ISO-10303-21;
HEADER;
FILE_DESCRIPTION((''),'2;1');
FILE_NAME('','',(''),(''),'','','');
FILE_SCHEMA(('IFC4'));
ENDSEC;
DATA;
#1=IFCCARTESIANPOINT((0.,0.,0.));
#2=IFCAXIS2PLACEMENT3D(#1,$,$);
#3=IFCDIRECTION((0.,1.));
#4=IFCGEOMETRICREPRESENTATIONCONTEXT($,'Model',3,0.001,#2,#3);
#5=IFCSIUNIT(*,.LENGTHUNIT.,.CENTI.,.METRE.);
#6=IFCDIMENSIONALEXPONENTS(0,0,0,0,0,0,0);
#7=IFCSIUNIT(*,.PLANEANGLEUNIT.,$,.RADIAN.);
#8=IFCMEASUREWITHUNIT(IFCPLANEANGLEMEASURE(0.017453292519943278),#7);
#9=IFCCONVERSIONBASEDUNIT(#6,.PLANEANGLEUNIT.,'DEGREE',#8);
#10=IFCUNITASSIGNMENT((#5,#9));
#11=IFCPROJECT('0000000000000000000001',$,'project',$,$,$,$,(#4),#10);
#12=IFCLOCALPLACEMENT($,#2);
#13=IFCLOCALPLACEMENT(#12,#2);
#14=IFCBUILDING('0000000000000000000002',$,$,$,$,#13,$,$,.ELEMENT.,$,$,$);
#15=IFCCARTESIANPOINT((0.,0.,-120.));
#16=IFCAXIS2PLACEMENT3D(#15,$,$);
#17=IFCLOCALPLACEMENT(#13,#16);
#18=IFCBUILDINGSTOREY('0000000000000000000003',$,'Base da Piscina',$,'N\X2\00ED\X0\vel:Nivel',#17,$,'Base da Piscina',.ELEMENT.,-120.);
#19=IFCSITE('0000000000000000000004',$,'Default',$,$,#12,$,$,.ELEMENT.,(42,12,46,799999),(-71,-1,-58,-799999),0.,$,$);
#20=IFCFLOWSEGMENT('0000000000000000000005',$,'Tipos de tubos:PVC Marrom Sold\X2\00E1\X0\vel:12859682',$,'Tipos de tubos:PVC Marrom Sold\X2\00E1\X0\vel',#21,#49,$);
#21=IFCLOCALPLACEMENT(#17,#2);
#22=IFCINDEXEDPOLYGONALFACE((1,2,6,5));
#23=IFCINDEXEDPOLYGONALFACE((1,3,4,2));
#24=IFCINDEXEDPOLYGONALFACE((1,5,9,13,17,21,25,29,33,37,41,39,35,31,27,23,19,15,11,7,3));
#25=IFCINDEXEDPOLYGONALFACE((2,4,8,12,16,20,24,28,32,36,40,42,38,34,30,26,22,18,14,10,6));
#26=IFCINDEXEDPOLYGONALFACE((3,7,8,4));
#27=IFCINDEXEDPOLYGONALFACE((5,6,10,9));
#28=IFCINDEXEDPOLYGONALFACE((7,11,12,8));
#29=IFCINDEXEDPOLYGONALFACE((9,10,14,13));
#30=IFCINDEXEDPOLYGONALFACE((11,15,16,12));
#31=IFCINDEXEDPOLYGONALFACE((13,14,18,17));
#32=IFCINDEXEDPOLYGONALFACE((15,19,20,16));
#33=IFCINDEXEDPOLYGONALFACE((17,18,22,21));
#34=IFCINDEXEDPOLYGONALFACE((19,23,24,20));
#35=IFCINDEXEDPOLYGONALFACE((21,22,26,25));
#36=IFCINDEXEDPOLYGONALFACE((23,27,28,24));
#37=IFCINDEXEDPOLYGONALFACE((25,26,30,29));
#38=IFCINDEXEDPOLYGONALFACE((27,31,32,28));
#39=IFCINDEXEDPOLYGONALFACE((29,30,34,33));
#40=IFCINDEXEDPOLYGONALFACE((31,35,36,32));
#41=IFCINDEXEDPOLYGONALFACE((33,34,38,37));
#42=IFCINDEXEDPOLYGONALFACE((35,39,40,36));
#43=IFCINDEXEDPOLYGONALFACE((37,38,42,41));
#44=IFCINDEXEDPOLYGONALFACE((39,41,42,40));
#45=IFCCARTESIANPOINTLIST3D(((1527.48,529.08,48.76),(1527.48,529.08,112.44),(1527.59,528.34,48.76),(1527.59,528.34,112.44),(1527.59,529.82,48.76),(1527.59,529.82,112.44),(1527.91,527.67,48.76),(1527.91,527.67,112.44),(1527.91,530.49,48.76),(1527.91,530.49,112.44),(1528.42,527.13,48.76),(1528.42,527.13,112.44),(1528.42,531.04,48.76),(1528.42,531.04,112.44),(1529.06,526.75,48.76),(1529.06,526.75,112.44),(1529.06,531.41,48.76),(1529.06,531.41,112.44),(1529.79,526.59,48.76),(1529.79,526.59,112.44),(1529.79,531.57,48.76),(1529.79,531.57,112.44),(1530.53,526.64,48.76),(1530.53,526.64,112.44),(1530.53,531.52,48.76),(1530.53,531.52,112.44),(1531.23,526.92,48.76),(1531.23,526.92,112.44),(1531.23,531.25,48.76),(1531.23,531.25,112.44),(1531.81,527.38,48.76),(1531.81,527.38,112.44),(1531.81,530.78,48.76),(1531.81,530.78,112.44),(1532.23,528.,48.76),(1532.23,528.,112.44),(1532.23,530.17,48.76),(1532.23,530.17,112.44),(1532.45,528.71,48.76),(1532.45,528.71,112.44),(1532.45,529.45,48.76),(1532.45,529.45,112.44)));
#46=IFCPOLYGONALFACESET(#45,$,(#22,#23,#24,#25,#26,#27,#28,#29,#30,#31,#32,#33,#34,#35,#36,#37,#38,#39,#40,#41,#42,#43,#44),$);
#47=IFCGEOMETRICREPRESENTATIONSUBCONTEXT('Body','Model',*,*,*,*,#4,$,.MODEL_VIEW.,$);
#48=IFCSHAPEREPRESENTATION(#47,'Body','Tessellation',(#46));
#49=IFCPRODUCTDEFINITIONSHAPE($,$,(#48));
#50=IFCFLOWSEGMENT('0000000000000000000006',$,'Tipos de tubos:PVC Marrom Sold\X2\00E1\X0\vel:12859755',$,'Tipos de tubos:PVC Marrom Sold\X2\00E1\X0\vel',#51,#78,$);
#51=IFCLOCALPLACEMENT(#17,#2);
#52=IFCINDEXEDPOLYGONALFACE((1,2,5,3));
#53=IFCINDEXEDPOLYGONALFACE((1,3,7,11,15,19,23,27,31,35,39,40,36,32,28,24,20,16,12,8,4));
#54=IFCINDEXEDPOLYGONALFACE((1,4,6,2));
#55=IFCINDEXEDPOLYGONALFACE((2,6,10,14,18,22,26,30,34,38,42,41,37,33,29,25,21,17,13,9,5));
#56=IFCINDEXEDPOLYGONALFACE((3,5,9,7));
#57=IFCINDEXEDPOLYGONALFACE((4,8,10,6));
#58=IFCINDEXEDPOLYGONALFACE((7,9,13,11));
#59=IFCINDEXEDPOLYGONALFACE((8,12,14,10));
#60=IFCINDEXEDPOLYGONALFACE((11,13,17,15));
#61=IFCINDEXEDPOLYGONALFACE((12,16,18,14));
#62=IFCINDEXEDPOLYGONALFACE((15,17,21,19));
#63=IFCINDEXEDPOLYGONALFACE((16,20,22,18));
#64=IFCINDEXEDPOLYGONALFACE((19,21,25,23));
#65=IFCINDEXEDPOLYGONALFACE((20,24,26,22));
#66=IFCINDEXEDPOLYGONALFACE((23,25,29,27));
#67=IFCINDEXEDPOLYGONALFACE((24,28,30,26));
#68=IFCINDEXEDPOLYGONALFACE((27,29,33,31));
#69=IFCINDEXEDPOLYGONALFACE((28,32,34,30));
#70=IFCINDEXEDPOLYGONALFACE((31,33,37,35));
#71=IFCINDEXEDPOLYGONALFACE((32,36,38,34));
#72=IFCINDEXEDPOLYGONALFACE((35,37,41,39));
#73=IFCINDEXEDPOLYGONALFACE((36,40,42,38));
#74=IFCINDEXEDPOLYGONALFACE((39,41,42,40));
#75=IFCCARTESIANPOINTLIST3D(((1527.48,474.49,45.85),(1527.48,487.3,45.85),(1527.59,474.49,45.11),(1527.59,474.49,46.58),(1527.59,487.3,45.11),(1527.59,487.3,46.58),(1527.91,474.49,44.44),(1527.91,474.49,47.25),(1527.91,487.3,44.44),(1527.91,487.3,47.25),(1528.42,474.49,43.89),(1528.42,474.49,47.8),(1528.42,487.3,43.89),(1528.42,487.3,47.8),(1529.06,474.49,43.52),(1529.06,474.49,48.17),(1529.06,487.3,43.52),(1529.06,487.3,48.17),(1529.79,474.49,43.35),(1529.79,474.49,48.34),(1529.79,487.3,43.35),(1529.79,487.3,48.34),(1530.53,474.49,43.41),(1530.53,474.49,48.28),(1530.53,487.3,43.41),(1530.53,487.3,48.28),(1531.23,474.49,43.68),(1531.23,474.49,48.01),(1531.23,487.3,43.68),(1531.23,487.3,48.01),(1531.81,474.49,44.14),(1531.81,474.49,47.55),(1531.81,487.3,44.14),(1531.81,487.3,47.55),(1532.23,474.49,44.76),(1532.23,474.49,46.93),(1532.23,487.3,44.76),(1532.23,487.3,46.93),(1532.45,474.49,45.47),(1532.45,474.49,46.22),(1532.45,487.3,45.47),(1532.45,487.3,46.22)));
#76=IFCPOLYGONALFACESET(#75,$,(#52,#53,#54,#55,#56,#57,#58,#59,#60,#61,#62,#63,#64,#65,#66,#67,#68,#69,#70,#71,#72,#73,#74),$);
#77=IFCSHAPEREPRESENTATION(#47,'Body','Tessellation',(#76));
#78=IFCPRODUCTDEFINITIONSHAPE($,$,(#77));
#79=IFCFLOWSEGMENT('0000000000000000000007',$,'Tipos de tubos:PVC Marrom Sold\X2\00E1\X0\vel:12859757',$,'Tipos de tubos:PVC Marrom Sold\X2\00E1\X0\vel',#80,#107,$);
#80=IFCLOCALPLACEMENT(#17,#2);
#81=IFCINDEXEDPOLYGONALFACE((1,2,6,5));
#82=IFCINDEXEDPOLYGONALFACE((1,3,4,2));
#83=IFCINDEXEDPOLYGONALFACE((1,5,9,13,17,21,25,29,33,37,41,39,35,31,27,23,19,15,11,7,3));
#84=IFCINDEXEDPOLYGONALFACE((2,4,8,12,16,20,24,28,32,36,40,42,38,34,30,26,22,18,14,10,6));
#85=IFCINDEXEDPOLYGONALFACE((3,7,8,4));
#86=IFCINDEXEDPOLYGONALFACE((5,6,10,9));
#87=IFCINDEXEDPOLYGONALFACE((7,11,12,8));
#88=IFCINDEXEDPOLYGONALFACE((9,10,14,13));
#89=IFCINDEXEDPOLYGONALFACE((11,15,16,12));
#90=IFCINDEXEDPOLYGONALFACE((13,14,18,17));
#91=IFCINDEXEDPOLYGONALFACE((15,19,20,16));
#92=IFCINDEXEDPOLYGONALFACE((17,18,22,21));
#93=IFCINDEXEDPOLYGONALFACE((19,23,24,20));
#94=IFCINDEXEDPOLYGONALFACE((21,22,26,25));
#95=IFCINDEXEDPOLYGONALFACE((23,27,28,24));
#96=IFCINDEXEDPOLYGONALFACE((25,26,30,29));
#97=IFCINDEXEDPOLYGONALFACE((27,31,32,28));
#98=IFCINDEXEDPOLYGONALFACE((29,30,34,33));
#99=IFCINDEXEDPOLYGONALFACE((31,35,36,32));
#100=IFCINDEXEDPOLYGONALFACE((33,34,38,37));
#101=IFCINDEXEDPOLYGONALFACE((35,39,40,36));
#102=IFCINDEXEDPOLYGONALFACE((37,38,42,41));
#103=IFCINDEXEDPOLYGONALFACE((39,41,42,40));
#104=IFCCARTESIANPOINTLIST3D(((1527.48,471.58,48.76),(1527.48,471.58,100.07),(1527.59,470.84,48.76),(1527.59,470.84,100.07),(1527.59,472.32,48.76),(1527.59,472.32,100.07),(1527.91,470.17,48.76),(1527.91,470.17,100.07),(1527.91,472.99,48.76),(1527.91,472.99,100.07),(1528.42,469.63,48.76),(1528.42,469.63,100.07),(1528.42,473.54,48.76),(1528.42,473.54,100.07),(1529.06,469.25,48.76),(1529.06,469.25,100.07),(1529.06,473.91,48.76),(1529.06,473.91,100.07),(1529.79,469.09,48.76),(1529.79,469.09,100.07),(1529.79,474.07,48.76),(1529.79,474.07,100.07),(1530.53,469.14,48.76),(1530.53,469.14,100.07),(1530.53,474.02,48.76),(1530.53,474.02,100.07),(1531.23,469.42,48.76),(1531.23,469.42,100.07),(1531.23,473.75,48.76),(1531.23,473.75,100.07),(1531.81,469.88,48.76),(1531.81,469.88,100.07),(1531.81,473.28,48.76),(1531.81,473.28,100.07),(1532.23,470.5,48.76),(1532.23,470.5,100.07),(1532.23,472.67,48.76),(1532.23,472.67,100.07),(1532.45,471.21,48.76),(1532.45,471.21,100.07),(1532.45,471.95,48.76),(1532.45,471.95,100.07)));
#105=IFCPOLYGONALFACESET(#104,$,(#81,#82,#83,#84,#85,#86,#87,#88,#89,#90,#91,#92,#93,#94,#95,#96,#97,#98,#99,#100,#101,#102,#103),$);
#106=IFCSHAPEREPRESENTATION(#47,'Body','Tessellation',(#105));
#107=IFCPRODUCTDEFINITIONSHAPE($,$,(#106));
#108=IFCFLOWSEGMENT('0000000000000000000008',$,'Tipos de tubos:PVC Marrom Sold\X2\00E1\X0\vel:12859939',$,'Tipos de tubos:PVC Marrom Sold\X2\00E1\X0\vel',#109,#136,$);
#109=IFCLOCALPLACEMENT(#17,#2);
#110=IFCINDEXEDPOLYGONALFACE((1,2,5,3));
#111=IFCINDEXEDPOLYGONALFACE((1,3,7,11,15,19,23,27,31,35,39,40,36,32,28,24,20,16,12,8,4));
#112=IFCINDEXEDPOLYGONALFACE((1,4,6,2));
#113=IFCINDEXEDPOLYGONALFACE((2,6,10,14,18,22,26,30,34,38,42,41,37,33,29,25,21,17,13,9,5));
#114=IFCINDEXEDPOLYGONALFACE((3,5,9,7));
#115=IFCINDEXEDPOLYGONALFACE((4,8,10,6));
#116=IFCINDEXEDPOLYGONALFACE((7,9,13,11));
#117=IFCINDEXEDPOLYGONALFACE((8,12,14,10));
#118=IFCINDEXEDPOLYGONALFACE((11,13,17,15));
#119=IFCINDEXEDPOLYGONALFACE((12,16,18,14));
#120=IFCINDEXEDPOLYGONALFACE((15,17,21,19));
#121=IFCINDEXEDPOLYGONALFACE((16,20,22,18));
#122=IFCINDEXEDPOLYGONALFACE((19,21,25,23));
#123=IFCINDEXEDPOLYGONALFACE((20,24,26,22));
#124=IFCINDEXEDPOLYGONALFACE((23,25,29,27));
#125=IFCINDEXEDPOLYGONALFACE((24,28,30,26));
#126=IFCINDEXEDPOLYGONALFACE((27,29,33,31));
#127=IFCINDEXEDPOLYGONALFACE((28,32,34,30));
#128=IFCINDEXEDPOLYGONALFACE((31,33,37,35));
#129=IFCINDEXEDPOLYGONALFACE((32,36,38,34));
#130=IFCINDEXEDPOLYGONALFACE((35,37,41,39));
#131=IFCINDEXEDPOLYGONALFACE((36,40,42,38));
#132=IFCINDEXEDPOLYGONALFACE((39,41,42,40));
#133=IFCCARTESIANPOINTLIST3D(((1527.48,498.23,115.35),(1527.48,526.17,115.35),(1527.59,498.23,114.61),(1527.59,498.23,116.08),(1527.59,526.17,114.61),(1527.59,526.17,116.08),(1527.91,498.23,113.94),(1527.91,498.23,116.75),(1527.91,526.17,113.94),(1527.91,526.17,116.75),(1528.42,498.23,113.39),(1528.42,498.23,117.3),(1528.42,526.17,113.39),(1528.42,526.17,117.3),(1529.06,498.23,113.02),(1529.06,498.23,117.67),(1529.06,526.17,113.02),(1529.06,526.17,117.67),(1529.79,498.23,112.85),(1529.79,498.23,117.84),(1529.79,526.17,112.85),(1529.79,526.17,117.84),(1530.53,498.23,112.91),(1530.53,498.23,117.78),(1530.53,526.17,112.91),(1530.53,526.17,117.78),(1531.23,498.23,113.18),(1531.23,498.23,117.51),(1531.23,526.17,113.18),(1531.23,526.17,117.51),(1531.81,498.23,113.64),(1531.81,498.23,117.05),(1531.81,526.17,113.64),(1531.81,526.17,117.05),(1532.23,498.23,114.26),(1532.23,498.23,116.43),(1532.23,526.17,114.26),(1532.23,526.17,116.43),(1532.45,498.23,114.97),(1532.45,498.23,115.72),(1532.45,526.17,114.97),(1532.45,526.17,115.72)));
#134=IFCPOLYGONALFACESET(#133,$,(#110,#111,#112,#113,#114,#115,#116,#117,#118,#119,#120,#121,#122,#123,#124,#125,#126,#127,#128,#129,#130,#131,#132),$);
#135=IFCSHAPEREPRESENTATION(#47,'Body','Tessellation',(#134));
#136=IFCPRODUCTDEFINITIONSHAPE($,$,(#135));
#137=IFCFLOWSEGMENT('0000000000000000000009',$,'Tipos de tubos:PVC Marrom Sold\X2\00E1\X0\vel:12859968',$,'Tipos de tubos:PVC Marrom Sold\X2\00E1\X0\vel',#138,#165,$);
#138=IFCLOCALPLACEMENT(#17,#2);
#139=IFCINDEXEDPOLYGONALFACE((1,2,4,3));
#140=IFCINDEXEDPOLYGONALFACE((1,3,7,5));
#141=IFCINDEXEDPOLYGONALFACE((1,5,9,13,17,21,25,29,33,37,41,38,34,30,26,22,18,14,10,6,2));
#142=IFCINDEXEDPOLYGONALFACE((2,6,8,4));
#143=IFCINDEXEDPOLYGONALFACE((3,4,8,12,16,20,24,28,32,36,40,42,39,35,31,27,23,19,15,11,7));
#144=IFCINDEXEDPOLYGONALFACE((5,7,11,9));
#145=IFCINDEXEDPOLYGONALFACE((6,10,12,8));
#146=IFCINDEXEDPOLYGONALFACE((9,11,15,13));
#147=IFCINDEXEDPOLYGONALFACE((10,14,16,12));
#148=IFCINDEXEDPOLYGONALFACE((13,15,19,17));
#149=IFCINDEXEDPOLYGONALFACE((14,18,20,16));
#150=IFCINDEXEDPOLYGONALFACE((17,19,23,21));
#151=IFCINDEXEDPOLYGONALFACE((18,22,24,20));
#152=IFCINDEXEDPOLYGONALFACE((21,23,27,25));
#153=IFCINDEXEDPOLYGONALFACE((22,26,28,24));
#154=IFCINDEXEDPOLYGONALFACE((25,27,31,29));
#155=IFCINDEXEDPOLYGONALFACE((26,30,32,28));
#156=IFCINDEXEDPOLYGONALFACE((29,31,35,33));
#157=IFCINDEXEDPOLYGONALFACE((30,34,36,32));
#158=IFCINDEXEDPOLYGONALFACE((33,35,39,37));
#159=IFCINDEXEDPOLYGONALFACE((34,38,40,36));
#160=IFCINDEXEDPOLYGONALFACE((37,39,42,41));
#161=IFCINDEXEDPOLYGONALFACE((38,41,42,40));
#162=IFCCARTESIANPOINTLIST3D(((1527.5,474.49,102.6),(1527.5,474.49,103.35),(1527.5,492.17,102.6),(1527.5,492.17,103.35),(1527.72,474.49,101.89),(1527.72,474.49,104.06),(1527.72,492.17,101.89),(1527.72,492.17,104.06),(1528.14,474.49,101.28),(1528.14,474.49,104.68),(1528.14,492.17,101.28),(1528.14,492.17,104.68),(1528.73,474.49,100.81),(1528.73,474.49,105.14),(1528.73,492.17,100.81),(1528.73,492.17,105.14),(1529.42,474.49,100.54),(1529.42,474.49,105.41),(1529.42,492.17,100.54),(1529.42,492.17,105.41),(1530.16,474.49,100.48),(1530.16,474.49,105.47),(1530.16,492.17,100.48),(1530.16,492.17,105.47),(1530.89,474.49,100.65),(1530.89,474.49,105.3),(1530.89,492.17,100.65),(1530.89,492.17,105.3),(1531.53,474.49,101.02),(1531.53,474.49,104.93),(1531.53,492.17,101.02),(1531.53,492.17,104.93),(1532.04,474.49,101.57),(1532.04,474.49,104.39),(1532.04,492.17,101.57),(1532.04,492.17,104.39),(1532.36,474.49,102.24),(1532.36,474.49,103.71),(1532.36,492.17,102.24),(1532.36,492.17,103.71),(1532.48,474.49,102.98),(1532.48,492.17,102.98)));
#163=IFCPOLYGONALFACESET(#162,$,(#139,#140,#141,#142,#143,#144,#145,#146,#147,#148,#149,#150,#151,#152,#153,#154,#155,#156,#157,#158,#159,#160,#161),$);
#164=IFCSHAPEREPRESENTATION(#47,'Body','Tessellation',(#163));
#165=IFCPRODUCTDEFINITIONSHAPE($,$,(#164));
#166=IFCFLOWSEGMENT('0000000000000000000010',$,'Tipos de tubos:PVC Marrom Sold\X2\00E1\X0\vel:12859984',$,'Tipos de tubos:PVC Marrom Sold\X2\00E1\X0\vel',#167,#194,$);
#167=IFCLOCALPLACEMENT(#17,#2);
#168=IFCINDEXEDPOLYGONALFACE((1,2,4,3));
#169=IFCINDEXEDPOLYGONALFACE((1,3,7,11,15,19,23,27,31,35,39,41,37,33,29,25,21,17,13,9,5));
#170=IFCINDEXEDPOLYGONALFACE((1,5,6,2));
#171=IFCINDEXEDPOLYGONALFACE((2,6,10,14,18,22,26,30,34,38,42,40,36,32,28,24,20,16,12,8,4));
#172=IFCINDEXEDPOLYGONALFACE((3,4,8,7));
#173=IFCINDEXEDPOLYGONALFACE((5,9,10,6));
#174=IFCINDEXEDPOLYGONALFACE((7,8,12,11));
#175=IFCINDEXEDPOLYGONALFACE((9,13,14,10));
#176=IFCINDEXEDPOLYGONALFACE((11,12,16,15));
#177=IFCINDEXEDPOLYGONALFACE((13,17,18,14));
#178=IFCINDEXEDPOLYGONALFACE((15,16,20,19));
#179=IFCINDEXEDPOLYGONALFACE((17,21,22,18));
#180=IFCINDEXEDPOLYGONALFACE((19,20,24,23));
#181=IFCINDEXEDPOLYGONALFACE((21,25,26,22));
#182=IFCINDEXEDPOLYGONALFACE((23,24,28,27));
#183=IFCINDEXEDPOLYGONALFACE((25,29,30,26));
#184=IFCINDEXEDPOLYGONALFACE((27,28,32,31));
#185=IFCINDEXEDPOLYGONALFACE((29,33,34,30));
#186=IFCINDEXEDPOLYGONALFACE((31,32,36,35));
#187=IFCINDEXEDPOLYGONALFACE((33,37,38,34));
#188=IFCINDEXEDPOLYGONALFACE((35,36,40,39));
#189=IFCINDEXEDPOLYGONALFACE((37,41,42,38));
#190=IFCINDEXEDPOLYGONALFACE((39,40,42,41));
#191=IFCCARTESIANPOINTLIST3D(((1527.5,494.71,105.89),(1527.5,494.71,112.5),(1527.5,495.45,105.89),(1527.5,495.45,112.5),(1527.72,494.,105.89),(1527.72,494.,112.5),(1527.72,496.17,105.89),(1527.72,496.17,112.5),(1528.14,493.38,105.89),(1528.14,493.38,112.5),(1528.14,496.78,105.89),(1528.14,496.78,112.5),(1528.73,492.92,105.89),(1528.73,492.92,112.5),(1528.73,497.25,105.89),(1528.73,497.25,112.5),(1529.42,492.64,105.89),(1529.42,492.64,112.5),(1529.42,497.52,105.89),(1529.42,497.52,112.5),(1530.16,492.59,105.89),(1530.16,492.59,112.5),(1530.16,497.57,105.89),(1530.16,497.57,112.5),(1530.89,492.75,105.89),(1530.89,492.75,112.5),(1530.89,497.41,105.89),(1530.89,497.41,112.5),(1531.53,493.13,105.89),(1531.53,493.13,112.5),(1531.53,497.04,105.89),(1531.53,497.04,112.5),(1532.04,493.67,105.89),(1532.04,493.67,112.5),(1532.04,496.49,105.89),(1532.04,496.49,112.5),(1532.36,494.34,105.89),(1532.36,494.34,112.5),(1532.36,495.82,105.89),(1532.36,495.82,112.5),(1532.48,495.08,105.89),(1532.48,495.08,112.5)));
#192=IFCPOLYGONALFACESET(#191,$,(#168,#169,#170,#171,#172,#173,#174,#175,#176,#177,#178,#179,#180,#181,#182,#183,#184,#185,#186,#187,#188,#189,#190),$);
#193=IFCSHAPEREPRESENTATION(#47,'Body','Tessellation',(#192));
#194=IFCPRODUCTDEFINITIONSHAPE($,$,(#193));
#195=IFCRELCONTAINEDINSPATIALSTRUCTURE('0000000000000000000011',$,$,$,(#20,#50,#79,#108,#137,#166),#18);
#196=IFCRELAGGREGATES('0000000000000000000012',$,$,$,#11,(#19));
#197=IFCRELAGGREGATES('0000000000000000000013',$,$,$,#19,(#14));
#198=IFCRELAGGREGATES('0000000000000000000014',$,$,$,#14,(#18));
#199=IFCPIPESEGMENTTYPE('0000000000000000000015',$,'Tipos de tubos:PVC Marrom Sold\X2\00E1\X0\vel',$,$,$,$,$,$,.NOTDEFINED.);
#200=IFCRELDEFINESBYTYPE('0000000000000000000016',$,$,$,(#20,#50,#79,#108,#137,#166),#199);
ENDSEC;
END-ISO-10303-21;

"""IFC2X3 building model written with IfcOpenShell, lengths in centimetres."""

from ifc_helpers import new_model, entity, si_unit, converted_unit, direction, frame, frame_2d, origin, origin_2d_with_axis, place, context, subcontext, project, spatial, circle, extrude, type_object, element, save


model = new_model("IFC2X3")

# Units and contexts
model_context = context("Model", 3, precision=0.001, world=origin(), true_north=direction((0.0, 1.0)))
body_context = subcontext(model_context, "Body", "Model", "MODEL_VIEW")
ifc_project = project(units=[si_unit("LENGTHUNIT", "METRE", prefix="CENTI"), converted_unit("PLANEANGLEUNIT", "DEGREE", entity("IfcPlaneAngleMeasure", 0.017453292519943278), si_unit("PLANEANGLEUNIT", "RADIAN"), dimensions=[0, 0, 0, 0, 0, 0, 0])], contexts=[model_context])

# Site, building, storey
site_placement = place(None, origin())
site = spatial("IfcSite", under=ifc_project, at=site_placement, Name="Default", CompositionType="ELEMENT", RefLatitude=(42, 12, 46, 799999), RefLongitude=(-71, -1, -58, -799999), RefElevation=0.0)
building_placement = place(site_placement, origin())
building = spatial("IfcBuilding", under=site, at=building_placement, CompositionType="ELEMENT")
storey_placement = place(building_placement, frame((0.0, 0.0, -120.0)))
storey = spatial("IfcBuildingStorey", under=building, at=storey_placement, Name="Base da Piscina", ObjectType="Nível:Nivel", LongName="Base da Piscina", CompositionType="ELEMENT", Elevation=-120.0)

# Flow segments
pipe_segment_type = type_object("IfcPipeSegmentType", Name="Tipos de tubos:PVC Marrom Soldável", PredefinedType="NOTDEFINED")
flow_segment_1_placement = place(storey_placement, origin())
element("IfcFlowSegment", 1, at=flow_segment_1_placement, inside=storey, type_object=pipe_segment_type, Name="Tipos de tubos:PVC Marrom Soldável:12859682", ObjectType="Tipos de tubos:PVC Marrom Soldável", context=body_context, shape_type="SweptSolid", body=[
    extrude(circle(Radius=2.5, at=origin_2d_with_axis()), frame((1529.98, 529.08, 48.76), z_axis=(0.0, 0.0, 1.0), x_axis=(-1.0, 0.0, 0.0)), (0.0, 0.0, 1.0), 63.68),
])
flow_segment_2_placement = place(storey_placement, origin())
element("IfcFlowSegment", 2, at=flow_segment_2_placement, inside=storey, type_object=pipe_segment_type, Name="Tipos de tubos:PVC Marrom Soldável:12859755", ObjectType="Tipos de tubos:PVC Marrom Soldável", context=body_context, shape_type="SweptSolid", body=[
    extrude(circle(Radius=2.5, at=frame_2d((0.0, 0.0), x_axis=(1.0, 0.0))), frame((1529.98, 474.49, 45.85), z_axis=(0.0, 1.0, 0.0), x_axis=(-1.0, 0.0, 0.0)), (0.0, 0.0, 1.0), 12.81),
])
flow_segment_3_placement = place(storey_placement, origin())
element("IfcFlowSegment", 3, at=flow_segment_3_placement, inside=storey, type_object=pipe_segment_type, Name="Tipos de tubos:PVC Marrom Soldável:12859757", ObjectType="Tipos de tubos:PVC Marrom Soldável", context=body_context, shape_type="SweptSolid", body=[
    extrude(circle(Radius=2.5, at=origin_2d_with_axis()), frame((1529.98, 471.58, 48.76), z_axis=(0.0, 0.0, 1.0), x_axis=(-1.0, 0.0, 0.0)), (0.0, 0.0, 1.0), 51.31),
])
flow_segment_4_placement = place(storey_placement, origin())
element("IfcFlowSegment", 4, at=flow_segment_4_placement, inside=storey, type_object=pipe_segment_type, Name="Tipos de tubos:PVC Marrom Soldável:12859939", ObjectType="Tipos de tubos:PVC Marrom Soldável", context=body_context, shape_type="SweptSolid", body=[
    extrude(circle(Radius=2.5, at=frame_2d((0.0, 0.0), x_axis=(1.0, 0.0))), frame((1529.98, 498.23, 115.35), z_axis=(0.0, 1.0, 0.0), x_axis=(-1.0, 0.0, 0.0)), (0.0, 0.0, 1.0), 27.94),
])
flow_segment_5_placement = place(storey_placement, origin())
element("IfcFlowSegment", 5, at=flow_segment_5_placement, inside=storey, type_object=pipe_segment_type, Name="Tipos de tubos:PVC Marrom Soldável:12859968", ObjectType="Tipos de tubos:PVC Marrom Soldável", context=body_context, shape_type="SweptSolid", body=[
    extrude(circle(Radius=2.5, at=frame_2d((0.0, 0.0), x_axis=(1.0, 0.0))), frame((1529.98, 474.49, 102.98), z_axis=(0.0, 1.0, 0.0), x_axis=(1.0, 0.0, 0.0)), (0.0, 0.0, 1.0), 17.68),
])
flow_segment_6_placement = place(storey_placement, origin())
element("IfcFlowSegment", 6, at=flow_segment_6_placement, inside=storey, type_object=pipe_segment_type, Name="Tipos de tubos:PVC Marrom Soldável:12859984", ObjectType="Tipos de tubos:PVC Marrom Soldável", context=body_context, shape_type="SweptSolid", body=[
    extrude(circle(Radius=2.5, at=frame_2d((0.0, 0.0), x_axis=(1.0, 0.0))), frame((1529.98, 495.08, 105.89)), (0.0, 0.0, 1.0), 6.61),
])

save(model, "model.ifc")
